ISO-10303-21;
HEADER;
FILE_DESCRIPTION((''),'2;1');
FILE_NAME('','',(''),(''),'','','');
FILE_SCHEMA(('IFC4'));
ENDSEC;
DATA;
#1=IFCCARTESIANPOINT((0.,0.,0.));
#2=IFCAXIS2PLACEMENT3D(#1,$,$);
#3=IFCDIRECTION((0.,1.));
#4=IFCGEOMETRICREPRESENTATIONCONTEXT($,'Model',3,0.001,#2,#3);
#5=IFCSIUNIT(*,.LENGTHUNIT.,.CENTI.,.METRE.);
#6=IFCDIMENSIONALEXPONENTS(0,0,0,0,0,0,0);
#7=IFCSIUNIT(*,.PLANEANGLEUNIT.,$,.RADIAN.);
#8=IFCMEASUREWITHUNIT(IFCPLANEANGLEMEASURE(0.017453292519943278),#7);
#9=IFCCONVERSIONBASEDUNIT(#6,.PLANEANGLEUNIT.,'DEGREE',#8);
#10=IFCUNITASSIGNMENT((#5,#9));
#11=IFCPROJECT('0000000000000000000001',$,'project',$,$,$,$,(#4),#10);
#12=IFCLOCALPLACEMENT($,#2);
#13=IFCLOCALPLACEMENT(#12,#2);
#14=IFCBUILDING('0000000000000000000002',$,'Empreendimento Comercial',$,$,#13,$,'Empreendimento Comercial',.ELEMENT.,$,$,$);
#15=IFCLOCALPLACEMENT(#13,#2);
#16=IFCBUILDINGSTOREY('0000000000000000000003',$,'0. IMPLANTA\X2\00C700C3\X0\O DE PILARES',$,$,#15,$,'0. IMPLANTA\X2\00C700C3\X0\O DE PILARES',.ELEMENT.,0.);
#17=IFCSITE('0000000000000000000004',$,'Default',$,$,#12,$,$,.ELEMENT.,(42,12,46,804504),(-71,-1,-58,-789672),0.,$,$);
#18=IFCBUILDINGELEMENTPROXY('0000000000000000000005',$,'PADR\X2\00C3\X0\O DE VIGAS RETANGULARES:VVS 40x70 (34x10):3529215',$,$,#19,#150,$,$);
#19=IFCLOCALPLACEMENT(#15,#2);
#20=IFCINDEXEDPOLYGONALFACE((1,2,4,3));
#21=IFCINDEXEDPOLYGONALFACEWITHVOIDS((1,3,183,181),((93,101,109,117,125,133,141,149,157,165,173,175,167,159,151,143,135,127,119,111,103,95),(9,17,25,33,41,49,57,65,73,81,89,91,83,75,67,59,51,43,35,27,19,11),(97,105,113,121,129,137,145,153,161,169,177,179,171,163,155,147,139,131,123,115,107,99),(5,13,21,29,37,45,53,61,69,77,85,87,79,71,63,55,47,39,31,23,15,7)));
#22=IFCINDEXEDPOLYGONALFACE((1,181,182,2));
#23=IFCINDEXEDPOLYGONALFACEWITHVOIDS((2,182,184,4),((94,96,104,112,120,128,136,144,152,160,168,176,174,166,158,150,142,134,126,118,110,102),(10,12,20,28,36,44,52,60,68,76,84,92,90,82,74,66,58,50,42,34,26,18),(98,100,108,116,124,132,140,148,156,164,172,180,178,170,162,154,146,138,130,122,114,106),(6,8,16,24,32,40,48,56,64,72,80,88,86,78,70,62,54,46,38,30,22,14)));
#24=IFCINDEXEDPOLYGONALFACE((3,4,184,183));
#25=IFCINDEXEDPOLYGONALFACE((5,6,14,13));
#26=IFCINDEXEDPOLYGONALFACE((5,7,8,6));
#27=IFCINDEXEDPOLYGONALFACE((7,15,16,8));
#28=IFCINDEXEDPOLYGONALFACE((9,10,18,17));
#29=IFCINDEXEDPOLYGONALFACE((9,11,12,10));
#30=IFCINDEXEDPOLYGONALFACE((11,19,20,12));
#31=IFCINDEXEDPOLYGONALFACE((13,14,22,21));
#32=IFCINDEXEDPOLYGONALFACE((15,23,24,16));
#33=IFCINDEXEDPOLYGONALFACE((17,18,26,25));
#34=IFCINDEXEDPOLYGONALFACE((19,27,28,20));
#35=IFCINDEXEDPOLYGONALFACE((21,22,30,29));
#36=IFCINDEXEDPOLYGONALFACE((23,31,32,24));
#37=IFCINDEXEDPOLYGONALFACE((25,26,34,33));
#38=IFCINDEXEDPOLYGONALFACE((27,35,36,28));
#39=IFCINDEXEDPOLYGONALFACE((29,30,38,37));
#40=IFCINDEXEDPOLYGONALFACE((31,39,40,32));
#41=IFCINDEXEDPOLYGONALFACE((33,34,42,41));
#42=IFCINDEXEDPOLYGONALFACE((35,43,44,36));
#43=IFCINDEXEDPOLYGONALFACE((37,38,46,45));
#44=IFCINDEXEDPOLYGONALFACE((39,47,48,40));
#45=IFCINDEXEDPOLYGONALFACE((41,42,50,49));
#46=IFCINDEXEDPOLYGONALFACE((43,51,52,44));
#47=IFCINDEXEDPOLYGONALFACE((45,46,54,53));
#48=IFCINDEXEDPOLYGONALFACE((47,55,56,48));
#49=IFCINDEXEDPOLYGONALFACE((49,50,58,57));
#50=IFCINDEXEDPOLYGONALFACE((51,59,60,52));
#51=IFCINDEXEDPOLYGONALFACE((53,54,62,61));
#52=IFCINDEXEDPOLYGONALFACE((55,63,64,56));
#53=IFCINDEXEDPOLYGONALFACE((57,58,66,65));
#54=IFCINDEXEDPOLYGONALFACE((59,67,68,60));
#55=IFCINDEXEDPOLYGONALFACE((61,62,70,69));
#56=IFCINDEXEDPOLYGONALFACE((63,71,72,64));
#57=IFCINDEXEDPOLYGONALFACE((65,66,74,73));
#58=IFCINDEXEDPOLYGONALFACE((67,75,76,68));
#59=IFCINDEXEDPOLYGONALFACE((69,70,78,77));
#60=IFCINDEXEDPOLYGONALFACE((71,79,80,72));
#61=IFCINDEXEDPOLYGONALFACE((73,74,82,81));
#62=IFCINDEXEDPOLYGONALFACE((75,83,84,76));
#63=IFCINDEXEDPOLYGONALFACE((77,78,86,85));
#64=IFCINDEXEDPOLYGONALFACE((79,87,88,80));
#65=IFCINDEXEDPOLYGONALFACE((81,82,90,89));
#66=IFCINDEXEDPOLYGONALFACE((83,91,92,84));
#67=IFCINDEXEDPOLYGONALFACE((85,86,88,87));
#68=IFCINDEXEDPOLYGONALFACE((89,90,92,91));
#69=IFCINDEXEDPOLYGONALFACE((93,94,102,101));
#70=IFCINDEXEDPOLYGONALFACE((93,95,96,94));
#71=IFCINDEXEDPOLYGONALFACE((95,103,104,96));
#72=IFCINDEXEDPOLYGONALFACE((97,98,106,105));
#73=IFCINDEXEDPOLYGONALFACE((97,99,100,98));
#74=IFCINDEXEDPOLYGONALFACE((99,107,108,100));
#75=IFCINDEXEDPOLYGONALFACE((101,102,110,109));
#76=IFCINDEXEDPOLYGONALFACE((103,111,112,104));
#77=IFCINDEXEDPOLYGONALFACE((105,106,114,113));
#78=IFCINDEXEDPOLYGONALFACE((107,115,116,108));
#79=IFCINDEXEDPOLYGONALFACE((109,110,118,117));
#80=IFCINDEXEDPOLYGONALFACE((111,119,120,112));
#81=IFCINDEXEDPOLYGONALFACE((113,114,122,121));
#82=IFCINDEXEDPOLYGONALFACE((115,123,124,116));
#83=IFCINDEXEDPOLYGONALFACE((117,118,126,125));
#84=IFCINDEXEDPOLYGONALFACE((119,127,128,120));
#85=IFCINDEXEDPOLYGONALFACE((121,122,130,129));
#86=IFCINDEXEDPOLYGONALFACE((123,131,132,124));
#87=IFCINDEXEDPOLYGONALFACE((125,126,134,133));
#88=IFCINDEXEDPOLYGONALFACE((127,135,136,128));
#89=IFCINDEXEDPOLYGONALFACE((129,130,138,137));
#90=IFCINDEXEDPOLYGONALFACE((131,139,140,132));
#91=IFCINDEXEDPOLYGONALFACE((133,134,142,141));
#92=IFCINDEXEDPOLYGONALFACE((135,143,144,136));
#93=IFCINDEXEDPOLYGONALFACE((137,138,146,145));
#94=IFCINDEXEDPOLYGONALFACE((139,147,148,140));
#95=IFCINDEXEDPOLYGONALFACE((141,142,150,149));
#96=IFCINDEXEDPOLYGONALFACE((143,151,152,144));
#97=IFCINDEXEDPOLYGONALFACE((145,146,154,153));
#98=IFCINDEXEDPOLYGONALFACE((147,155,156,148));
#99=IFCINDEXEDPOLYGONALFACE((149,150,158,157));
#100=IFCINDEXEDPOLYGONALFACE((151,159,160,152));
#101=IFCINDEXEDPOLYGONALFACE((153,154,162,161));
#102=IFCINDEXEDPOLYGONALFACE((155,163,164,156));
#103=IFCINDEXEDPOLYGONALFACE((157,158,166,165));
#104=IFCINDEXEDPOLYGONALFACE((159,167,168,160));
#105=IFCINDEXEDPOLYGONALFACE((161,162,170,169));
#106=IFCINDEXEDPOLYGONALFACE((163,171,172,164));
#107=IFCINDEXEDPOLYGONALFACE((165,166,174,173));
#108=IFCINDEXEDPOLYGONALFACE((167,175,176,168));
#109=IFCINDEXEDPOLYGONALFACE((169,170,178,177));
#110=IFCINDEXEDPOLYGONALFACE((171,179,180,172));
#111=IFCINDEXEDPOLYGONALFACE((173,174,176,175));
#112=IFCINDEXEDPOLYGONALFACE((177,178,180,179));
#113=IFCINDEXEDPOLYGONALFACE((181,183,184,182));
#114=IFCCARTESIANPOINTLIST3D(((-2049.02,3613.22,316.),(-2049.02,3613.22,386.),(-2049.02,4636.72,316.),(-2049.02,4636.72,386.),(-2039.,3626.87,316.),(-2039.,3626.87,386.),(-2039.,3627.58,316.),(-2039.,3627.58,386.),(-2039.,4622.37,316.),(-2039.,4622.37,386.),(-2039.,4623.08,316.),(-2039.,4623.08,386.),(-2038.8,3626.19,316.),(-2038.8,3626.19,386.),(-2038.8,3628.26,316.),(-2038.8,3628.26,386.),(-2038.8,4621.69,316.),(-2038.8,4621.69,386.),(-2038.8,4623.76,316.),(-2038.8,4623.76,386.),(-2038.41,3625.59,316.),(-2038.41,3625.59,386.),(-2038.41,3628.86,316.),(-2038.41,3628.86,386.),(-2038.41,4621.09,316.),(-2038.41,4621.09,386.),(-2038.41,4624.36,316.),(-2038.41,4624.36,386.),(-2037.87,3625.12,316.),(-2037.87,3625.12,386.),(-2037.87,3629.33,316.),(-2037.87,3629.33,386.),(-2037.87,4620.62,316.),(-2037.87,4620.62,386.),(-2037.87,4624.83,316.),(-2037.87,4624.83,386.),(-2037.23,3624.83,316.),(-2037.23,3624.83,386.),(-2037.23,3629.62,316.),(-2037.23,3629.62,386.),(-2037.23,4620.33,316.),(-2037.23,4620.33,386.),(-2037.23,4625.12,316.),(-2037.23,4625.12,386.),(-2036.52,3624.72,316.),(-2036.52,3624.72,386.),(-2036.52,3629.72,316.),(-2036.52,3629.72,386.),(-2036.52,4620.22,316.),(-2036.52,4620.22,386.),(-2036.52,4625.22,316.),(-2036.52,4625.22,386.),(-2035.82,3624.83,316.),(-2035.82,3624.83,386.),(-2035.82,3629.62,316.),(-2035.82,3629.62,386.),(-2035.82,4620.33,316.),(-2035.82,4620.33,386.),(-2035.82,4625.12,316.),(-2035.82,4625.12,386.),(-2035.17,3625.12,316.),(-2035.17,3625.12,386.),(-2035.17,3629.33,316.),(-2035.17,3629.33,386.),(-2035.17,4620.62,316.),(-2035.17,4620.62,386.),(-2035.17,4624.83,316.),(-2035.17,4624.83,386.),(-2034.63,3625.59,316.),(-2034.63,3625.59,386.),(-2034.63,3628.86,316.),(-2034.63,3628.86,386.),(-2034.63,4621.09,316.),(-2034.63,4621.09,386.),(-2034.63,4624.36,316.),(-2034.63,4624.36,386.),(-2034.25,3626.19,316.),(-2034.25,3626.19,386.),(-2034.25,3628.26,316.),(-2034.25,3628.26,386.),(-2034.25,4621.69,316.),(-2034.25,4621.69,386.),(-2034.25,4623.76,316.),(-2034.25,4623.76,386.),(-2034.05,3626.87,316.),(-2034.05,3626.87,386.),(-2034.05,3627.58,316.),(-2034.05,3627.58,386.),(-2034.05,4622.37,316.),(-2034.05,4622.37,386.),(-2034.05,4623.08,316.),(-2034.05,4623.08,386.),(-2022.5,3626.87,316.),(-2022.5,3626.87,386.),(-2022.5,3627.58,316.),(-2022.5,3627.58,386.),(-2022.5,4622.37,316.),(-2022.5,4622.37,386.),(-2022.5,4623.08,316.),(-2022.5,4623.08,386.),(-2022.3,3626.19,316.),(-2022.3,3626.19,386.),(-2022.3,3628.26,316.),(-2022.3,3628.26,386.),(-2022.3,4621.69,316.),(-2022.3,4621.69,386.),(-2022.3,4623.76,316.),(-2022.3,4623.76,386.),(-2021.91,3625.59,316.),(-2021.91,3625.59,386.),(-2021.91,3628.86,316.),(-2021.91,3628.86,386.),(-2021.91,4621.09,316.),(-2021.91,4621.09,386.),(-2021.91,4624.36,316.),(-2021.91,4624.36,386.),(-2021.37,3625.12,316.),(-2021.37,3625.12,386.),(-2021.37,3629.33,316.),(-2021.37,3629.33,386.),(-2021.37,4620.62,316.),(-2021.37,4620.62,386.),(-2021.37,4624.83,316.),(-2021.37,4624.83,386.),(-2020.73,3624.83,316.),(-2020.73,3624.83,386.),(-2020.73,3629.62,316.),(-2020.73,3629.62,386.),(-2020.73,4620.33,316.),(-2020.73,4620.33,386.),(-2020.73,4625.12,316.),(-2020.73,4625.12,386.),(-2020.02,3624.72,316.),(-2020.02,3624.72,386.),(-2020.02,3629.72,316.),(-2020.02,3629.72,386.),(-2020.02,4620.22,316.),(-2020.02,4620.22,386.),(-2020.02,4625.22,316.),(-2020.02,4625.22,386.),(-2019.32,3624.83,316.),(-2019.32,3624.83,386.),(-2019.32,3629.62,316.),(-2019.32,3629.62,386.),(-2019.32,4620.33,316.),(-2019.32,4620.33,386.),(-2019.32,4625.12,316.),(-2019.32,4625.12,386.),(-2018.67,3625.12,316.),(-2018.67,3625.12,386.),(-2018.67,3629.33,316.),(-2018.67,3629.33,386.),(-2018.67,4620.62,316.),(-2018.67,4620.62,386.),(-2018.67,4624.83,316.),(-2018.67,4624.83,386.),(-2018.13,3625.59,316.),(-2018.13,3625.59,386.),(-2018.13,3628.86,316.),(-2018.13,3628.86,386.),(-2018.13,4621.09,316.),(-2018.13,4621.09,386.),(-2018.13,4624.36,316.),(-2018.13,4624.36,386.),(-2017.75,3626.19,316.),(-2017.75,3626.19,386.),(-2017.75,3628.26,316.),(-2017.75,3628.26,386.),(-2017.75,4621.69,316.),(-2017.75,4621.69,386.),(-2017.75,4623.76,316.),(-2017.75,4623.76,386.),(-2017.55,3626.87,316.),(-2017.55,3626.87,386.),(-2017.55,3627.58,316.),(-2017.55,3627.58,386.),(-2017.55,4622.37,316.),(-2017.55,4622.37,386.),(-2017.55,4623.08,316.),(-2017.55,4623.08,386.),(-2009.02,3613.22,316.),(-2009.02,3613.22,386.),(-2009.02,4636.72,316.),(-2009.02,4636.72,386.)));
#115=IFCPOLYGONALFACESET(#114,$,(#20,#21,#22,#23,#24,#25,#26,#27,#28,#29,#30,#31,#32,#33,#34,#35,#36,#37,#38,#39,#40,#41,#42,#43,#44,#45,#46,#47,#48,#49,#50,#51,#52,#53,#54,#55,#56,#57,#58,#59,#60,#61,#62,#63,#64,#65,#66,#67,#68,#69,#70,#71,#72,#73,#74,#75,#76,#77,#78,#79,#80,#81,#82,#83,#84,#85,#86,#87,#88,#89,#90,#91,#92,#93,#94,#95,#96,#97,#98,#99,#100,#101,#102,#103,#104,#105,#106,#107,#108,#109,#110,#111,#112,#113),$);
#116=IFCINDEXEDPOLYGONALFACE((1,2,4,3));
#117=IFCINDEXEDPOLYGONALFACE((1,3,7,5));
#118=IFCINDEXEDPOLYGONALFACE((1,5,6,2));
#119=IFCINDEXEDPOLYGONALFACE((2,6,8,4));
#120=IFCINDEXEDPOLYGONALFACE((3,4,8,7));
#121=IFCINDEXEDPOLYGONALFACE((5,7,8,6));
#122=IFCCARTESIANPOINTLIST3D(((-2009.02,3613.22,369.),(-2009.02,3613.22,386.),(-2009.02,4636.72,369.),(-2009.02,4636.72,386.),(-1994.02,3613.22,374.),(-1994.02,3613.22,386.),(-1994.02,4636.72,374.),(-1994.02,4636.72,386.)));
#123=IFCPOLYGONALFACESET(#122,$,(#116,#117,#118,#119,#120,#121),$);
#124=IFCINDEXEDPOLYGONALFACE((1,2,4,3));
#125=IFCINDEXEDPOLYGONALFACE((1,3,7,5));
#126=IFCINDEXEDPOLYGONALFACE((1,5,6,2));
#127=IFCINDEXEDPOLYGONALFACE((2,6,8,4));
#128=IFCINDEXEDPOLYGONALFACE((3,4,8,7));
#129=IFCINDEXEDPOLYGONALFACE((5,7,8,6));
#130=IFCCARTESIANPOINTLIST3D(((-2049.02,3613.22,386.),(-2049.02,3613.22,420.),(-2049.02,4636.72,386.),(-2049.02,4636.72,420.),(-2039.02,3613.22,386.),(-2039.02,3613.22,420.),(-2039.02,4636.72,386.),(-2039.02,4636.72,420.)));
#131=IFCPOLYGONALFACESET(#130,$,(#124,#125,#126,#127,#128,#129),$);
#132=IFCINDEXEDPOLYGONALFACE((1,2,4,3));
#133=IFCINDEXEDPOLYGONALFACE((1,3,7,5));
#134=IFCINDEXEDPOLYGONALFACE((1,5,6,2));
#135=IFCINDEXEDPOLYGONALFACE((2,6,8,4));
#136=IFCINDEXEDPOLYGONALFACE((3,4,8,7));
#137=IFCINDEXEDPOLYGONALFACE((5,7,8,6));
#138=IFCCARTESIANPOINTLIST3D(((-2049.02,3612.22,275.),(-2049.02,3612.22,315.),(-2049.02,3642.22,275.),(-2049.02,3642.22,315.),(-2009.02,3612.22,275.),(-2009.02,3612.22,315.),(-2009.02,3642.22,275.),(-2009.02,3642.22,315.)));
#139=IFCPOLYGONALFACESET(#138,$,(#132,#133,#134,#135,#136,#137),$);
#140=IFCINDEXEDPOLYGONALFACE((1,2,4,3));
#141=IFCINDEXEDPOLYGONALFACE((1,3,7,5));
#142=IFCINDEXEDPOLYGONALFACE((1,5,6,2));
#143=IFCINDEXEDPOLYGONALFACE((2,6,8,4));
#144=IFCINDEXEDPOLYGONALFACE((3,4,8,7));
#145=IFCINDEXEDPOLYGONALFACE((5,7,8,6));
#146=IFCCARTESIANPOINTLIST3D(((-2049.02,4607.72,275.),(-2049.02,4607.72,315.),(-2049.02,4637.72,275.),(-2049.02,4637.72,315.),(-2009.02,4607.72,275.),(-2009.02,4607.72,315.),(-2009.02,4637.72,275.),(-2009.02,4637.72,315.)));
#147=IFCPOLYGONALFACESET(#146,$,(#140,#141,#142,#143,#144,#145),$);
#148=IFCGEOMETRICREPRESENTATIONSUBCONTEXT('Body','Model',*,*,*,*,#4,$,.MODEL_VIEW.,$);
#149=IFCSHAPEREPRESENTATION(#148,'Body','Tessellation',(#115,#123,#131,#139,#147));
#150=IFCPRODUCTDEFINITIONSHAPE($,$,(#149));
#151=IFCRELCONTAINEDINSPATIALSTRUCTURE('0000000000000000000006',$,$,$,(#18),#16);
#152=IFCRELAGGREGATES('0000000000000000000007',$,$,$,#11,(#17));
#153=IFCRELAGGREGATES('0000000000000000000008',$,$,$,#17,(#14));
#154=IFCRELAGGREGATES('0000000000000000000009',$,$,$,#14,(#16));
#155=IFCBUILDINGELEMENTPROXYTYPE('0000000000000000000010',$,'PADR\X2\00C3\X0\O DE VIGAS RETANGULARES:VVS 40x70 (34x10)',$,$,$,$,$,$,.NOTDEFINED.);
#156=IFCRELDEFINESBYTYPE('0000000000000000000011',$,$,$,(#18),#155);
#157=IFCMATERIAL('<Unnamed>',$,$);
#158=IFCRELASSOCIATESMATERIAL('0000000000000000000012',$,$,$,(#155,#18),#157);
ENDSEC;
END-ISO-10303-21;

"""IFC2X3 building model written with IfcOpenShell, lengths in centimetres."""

from ifc_helpers import new_model, entity, si_unit, converted_unit, direction, frame, frame_2d, origin, place, context, subcontext, project, spatial, polyline, circle_curve, parameter, trimmed, segment, composite_curve, rectangle, outline, extrude, source, transform, mapped, material, type_object, type_shapes, element, save


model = new_model("IFC2X3")

# Units and contexts
model_context = context("Model", 3, precision=0.001, world=origin(), true_north=direction((0.0, 1.0)))
body_context = subcontext(model_context, "Body", "Model", "MODEL_VIEW")
ifc_project = project(units=[si_unit("LENGTHUNIT", "METRE", prefix="CENTI"), converted_unit("PLANEANGLEUNIT", "DEGREE", entity("IfcPlaneAngleMeasure", 0.017453292519943278), si_unit("PLANEANGLEUNIT", "RADIAN"), dimensions=[0, 0, 0, 0, 0, 0, 0])], contexts=[model_context])

# Site, building, storey
site_placement = place(None, origin())
site = spatial("IfcSite", under=ifc_project, at=site_placement, Name="Default", CompositionType="ELEMENT", RefLatitude=(42, 12, 46, 804504), RefLongitude=(-71, -1, -58, -789672), RefElevation=0.0)
building_placement = place(site_placement, origin())
building = spatial("IfcBuilding", under=site, at=building_placement, Name="Empreendimento Comercial", LongName="Empreendimento Comercial", CompositionType="ELEMENT")
storey_placement = place(building_placement, origin())
storey = spatial("IfcBuildingStorey", under=building, at=storey_placement, Name="0. IMPLANTAÇÃO DE PILARES", LongName="0. IMPLANTAÇÃO DE PILARES", CompositionType="ELEMENT", Elevation=0.0)

# Building element proxy
ifc_material_1 = material(Name="<Unnamed>")
building_element_proxy_type_1 = type_object("IfcBuildingElementProxyType", Name="PADRÃO DE VIGAS RETANGULARES:VVS 40x70 (34x10)", PredefinedType="NOTDEFINED", material=ifc_material_1)
shared_shape_1 = source(origin(), body_context, "Body", "SweptSolid", [
    extrude(outline(polyline([(-511.75, -20.0), (511.75, -20.0), (511.75, 20.0), (-511.75, 20.0), (-511.75, -20.0)]), holes=[composite_curve([segment(trimmed(circle_curve(frame_2d((-497.75, -7.5), x_axis=(-1.0, 0.0)), 2.5), [parameter(0.0)], [parameter(180.0)], True, "PARAMETER"), False, "CONTINUOUS"), segment(trimmed(circle_curve(frame_2d((-497.75, -7.5), x_axis=(-1.0, 0.0)), 2.5), [parameter(180.0)], [parameter(0.0)], True, "PARAMETER"), False, "CONTINUOUS")], self_intersect=False), composite_curve([segment(trimmed(circle_curve(frame_2d((-497.75, 9.0), x_axis=(-1.0, 0.0)), 2.5), [parameter(0.0)], [parameter(180.0)], True, "PARAMETER"), False, "CONTINUOUS"), segment(trimmed(circle_curve(frame_2d((-497.75, 9.0), x_axis=(-1.0, 0.0)), 2.5), [parameter(180.0)], [parameter(0.0)], True, "PARAMETER"), False, "CONTINUOUS")], self_intersect=False), composite_curve([segment(trimmed(circle_curve(frame_2d((497.75, 9.0), x_axis=(-1.0, 0.0)), 2.5), [parameter(0.0)], [parameter(180.0)], True, "PARAMETER"), False, "CONTINUOUS"), segment(trimmed(circle_curve(frame_2d((497.75, 9.0), x_axis=(-1.0, 0.0)), 2.5), [parameter(180.0)], [parameter(0.0)], True, "PARAMETER"), False, "CONTINUOUS")], self_intersect=False), composite_curve([segment(trimmed(circle_curve(frame_2d((497.75, -7.5), x_axis=(-1.0, 0.0)), 2.5), [parameter(0.0)], [parameter(180.0)], True, "PARAMETER"), False, "CONTINUOUS"), segment(trimmed(circle_curve(frame_2d((497.75, -7.5), x_axis=(-1.0, 0.0)), 2.5), [parameter(180.0)], [parameter(0.0)], True, "PARAMETER"), False, "CONTINUOUS")], self_intersect=False)]), frame((-2029.02, 4124.97, 316.0), z_axis=(0.0, 0.0, 1.0), x_axis=(0.0, -1.0, 0.0)), (0.0, 0.0, 1.0), 70.0),
    extrude(outline(polyline([(-7.25, -7.5), (4.75, -7.5), (9.75, 7.5), (-7.25, 7.5), (-7.25, -7.5)])), frame((-2001.52, 3613.22, 378.75), z_axis=(0.0, 1.0, 0.0), x_axis=(0.0, 0.0, -1.0)), (0.0, 0.0, 1.0), 1023.5),
    extrude(rectangle(XDim=1023.5, YDim=10.0, at=frame_2d((0.0, 0.0), x_axis=(1.0, 0.0))), frame((-2044.02, 4124.97, 386.0), z_axis=(0.0, 0.0, 1.0), x_axis=(0.0, -1.0, 0.0)), (0.0, 0.0, 1.0), 34.0),
    extrude(rectangle(XDim=40.0, YDim=30.0, at=frame_2d((0.0, 0.0), x_axis=(1.0, 0.0))), frame((-2029.02, 3627.22, 275.0), z_axis=(0.0, 0.0, 1.0), x_axis=(-1.0, 0.0, 0.0)), (0.0, 0.0, 1.0), 40.0),
    extrude(rectangle(XDim=40.0, YDim=30.0, at=frame_2d((0.0, 0.0), x_axis=(1.0, 0.0))), frame((-2029.02, 4622.72, 275.0), z_axis=(0.0, 0.0, 1.0), x_axis=(-1.0, 0.0, 0.0)), (0.0, 0.0, 1.0), 40.0),
])
type_shapes(building_element_proxy_type_1, [shared_shape_1])
proxy_1_placement = place(storey_placement, origin())
element("IfcBuildingElementProxy", 1, at=proxy_1_placement, inside=storey, type_object=building_element_proxy_type_1, material=ifc_material_1, Name="PADRÃO DE VIGAS RETANGULARES:VVS 40x70 (34x10):3529215", context=body_context, shape_type="MappedRepresentation", body=[
    mapped(shared_shape_1, transform((0.0, 0.0, 0.0), scale=1.0)),
])

save(model, "model.ifc")
